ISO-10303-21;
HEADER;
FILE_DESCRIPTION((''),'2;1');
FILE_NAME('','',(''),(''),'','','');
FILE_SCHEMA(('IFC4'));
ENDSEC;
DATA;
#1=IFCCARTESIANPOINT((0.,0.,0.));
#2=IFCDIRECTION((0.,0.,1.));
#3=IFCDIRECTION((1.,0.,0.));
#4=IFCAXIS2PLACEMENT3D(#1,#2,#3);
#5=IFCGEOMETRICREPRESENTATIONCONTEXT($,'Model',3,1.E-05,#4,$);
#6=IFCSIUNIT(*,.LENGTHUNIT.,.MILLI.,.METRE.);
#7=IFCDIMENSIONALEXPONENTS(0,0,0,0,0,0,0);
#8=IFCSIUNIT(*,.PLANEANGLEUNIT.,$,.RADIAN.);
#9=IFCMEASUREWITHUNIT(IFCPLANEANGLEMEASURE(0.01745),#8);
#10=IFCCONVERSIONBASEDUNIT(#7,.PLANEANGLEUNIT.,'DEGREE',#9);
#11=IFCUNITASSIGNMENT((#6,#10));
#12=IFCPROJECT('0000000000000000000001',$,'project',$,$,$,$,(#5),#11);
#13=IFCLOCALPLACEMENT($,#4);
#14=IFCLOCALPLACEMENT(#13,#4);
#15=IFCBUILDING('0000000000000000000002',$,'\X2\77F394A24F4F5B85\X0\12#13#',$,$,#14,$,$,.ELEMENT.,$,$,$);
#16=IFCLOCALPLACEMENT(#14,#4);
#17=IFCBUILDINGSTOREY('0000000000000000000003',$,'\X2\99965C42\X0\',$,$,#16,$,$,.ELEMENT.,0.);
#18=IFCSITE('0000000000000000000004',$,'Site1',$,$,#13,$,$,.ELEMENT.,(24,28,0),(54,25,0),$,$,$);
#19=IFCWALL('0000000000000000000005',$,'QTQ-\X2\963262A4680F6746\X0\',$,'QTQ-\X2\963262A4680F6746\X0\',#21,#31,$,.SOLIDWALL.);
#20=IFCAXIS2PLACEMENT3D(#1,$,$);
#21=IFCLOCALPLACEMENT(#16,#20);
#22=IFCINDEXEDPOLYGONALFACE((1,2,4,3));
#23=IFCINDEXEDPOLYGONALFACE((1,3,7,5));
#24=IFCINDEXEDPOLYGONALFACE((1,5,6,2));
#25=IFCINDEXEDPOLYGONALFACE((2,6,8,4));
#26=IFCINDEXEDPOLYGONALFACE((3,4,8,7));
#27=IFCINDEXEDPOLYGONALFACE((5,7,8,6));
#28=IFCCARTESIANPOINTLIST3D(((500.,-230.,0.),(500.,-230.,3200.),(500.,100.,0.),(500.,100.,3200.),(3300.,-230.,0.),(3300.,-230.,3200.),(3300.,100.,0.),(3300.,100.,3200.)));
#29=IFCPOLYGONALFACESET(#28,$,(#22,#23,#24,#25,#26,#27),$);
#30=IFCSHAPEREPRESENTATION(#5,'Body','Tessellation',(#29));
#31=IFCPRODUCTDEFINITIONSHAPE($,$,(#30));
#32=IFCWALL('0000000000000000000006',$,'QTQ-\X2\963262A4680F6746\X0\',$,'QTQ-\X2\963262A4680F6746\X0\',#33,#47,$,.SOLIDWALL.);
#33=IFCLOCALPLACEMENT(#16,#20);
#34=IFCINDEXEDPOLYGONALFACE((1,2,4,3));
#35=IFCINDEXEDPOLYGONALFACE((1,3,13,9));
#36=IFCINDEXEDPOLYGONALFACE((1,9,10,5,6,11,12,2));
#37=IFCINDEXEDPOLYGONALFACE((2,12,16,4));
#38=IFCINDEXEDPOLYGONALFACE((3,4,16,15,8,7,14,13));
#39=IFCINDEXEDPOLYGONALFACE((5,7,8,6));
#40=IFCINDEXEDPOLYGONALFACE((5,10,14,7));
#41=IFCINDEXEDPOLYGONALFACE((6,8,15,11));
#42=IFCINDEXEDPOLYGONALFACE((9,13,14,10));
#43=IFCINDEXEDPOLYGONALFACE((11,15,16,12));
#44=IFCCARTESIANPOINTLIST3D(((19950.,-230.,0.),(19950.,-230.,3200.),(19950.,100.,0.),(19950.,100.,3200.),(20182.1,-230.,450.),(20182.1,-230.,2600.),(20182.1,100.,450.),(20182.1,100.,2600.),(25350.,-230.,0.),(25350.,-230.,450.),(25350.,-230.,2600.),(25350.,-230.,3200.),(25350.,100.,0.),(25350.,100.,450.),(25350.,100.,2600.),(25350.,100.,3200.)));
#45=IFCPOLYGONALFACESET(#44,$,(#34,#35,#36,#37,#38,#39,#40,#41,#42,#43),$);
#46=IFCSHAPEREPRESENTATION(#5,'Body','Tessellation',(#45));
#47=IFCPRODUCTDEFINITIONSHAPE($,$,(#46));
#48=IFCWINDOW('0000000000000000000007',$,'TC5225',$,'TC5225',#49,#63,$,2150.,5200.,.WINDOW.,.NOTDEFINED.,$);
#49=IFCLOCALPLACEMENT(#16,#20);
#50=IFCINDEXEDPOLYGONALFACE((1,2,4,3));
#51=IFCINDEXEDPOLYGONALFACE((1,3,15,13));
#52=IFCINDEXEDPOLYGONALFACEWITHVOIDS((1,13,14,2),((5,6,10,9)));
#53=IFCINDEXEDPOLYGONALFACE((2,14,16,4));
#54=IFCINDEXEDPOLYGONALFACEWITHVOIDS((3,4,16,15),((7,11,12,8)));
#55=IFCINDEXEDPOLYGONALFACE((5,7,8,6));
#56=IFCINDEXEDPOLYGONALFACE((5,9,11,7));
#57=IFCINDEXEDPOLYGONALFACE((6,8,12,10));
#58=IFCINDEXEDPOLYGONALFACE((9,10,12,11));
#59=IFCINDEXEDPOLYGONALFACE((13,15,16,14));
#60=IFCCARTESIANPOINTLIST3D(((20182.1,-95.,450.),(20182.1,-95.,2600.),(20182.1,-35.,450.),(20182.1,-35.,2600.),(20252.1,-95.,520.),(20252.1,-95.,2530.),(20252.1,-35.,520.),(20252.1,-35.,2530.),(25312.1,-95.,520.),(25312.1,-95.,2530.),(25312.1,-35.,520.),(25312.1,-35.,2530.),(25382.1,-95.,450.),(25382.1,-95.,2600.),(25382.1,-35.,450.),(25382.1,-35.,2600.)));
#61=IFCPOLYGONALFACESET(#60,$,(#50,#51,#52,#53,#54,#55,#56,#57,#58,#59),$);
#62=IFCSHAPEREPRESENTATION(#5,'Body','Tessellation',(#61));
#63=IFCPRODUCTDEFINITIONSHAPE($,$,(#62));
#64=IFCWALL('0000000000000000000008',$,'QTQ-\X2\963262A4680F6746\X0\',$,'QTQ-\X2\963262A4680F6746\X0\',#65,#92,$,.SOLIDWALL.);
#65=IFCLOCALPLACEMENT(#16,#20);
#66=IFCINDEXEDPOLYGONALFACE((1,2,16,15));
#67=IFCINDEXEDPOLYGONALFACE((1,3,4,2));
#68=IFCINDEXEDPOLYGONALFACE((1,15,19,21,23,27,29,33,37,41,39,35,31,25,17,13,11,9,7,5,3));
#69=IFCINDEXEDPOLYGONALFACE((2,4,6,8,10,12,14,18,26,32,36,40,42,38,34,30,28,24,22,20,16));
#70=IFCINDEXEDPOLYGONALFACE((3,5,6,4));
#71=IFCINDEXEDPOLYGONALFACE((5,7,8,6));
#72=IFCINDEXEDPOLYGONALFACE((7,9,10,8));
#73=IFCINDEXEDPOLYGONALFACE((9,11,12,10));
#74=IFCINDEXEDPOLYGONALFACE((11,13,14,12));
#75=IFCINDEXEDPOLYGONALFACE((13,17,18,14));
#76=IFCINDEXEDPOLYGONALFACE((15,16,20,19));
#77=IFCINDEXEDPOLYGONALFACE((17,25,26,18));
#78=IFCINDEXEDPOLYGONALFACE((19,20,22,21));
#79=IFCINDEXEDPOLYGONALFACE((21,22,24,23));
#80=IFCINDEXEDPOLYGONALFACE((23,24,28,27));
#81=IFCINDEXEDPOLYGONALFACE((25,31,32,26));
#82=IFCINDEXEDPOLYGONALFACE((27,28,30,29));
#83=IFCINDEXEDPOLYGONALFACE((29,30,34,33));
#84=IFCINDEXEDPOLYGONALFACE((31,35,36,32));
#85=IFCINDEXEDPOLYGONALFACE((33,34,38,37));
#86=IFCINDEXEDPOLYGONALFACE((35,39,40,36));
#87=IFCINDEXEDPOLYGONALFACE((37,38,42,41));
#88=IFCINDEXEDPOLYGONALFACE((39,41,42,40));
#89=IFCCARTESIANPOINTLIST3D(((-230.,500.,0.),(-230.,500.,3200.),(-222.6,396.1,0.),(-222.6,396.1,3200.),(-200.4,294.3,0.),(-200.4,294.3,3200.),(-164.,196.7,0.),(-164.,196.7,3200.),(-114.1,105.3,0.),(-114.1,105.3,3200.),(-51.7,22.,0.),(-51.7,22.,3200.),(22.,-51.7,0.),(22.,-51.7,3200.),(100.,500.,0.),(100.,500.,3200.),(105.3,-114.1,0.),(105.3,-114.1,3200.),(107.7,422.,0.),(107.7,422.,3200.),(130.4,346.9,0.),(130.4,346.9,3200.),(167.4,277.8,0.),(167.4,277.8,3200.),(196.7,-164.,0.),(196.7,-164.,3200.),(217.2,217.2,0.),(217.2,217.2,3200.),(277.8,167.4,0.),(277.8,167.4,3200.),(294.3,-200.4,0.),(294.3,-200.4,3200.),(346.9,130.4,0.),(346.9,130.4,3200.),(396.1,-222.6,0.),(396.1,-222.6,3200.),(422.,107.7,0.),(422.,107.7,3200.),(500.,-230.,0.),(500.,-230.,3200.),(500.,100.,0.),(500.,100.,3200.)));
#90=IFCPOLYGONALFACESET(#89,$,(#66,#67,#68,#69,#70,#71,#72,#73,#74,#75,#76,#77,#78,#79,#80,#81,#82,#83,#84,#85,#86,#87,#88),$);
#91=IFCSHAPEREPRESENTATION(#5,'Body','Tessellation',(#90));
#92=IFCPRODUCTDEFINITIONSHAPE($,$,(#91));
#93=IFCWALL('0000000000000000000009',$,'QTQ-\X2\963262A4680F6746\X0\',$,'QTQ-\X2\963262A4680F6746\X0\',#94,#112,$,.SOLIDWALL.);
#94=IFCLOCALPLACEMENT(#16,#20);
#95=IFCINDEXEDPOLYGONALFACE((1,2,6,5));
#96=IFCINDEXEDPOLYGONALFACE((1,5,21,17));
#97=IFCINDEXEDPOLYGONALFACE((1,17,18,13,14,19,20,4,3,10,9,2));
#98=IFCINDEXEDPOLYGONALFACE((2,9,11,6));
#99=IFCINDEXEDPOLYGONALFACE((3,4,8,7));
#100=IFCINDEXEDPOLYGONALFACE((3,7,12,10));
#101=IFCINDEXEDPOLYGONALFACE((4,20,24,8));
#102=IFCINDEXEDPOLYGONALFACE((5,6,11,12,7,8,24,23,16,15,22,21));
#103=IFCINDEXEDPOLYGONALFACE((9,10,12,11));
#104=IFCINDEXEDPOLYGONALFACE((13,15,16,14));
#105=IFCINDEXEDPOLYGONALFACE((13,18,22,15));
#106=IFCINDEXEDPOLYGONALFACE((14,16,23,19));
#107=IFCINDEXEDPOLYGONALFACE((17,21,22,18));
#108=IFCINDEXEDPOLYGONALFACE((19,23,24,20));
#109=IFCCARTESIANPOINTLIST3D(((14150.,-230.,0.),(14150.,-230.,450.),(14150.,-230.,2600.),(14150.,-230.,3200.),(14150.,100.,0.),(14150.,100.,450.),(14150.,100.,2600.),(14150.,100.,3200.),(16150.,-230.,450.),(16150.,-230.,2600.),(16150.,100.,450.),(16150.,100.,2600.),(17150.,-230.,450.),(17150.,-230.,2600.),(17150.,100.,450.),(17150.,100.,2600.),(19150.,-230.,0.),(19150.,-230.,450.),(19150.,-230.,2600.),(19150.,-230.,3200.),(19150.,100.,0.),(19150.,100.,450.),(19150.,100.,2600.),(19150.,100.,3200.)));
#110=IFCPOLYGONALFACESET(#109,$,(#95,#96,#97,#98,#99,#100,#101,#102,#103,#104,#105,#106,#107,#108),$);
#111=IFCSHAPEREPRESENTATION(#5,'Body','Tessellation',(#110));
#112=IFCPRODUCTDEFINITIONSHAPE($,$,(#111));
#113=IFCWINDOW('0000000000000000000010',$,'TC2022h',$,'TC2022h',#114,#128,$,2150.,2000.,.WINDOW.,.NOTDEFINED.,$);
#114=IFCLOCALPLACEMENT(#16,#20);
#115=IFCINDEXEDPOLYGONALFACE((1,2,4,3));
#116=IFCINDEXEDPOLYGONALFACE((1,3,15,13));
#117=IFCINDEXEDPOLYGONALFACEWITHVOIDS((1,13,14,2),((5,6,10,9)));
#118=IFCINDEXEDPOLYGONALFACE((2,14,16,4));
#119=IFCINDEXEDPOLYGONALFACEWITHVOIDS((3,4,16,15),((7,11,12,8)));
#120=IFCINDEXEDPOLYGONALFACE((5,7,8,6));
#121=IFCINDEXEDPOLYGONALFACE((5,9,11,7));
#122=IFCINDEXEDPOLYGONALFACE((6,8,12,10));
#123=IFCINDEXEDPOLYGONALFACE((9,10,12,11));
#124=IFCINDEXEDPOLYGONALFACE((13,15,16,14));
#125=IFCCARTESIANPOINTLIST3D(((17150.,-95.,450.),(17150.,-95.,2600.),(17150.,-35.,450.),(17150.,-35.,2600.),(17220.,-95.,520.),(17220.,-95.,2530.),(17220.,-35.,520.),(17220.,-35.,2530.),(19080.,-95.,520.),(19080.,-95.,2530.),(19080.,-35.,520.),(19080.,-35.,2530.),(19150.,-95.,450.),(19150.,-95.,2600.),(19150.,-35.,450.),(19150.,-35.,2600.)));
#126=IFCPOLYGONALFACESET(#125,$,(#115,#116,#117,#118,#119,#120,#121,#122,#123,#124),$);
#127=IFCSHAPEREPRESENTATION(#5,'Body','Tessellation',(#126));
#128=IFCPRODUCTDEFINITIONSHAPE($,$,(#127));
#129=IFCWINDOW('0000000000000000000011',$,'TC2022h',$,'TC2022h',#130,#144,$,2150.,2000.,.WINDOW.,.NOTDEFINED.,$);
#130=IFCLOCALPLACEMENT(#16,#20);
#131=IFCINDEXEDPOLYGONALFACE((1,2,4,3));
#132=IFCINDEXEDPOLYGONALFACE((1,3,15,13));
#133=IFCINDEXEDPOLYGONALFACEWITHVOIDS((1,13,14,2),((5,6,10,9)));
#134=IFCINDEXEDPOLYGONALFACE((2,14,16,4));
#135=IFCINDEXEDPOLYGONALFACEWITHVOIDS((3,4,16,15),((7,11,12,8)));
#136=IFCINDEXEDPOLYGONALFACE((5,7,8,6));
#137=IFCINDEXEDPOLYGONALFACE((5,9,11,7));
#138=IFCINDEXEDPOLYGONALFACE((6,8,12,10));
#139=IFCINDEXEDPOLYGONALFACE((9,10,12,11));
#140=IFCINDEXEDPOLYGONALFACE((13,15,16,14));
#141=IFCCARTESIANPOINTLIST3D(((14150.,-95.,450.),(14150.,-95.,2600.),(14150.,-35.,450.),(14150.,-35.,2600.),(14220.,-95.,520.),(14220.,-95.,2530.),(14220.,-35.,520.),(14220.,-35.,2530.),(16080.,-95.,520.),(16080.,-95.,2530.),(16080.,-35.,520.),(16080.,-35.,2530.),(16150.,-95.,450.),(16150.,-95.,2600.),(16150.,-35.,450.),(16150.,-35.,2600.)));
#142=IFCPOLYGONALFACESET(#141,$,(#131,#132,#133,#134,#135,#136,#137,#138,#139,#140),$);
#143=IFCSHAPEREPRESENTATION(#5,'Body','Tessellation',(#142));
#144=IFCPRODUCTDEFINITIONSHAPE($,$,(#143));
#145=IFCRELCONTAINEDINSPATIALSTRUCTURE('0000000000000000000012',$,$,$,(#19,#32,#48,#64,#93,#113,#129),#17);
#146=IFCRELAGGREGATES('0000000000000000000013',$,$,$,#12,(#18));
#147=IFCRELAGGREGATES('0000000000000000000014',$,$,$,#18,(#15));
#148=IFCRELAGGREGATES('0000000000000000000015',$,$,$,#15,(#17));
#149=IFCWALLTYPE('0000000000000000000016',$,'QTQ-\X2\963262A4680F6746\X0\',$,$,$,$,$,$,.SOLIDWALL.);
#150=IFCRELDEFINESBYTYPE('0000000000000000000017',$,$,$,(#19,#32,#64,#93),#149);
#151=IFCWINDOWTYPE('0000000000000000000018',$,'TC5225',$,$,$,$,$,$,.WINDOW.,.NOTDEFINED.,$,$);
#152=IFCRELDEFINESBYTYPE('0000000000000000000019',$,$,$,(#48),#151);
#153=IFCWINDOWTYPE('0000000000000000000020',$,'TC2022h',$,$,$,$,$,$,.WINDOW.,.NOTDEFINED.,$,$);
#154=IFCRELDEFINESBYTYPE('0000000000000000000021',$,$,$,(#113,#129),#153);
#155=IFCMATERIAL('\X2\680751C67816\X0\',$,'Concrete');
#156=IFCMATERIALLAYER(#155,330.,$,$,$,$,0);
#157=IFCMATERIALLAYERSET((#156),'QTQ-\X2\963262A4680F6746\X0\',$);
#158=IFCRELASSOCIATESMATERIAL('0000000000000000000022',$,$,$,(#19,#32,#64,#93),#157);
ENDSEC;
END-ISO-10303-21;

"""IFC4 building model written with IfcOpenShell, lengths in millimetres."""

from ifc_helpers import new_model, entity, si_unit, converted_unit, point, frame, frame_2d, origin_with_axes, place, context, project, spatial, polyline, circle_curve, trimmed, segment, composite_curve, outline, extrude, material, layer, layer_set, type_object, element, fill, save


model = new_model("IFC4")

# Units and contexts
model_context = context("Model", 3, precision=1e-05, world=origin_with_axes())
ifc_project = project(units=[si_unit("LENGTHUNIT", "METRE", prefix="MILLI"), converted_unit("PLANEANGLEUNIT", "DEGREE", entity("IfcPlaneAngleMeasure", 0.01745), si_unit("PLANEANGLEUNIT", "RADIAN"), dimensions=[0, 0, 0, 0, 0, 0, 0])], contexts=[model_context])

# Site, building, storey
site_placement = place(None, origin_with_axes())
site = spatial("IfcSite", under=ifc_project, at=site_placement, Name="Site1", CompositionType="ELEMENT", RefLatitude=(24, 28, 0), RefLongitude=(54, 25, 0))
building_placement = place(site_placement, origin_with_axes())
building = spatial("IfcBuilding", under=site, at=building_placement, Name="石钢住宅12#13#", CompositionType="ELEMENT")
storey_placement = place(building_placement, origin_with_axes())
storey = spatial("IfcBuildingStorey", under=building, at=storey_placement, Name="首层", CompositionType="ELEMENT", Elevation=0.0)

# Wall
ifc_material_1 = material(Name="标准砖", Category="Concrete")
ifc_layer_1 = layer(ifc_material_1, 330.0, Priority=0)
ifc_layer_set_1 = layer_set([ifc_layer_1], Name="QTQ-防护栏杆")
wall_type_1 = type_object("IfcWallType", Name="QTQ-防护栏杆", PredefinedType="SOLIDWALL")
wall_1_placement = place(storey_placement, origin_with_axes())
element("IfcWall", 1, at=wall_1_placement, inside=storey, type_object=wall_type_1, material=ifc_layer_set_1, Name="QTQ-防护栏杆", ObjectType="QTQ-防护栏杆", PredefinedType="SOLIDWALL", context=model_context, shape_type="SweptSolid", body=[
    extrude(outline(polyline([(0.0, 0.0), (3200.0, 0.0), (3200.0, 2800.0), (0.0, 2800.0), (0.0, 0.0)])), frame((500.0, 100.0, 3200.0), z_axis=(0.0, -1.0, 0.0), x_axis=(0.0, 0.0, -1.0)), (0.0, 0.0, 1.0), 330.0),
])

# Wall, opening, window
wall_2_placement = place(storey_placement, origin_with_axes())
wall_2 = element("IfcWall", 2, at=wall_2_placement, inside=storey, type_object=wall_type_1, material=ifc_layer_set_1, Name="QTQ-防护栏杆", ObjectType="QTQ-防护栏杆", PredefinedType="SOLIDWALL", context=model_context, shape_type="SweptSolid", body=[
    extrude(outline(polyline([(0.0, 0.0), (3200.0, 0.0), (3200.0, 5400.0), (0.0, 5400.0), (0.0, 0.0)])), frame((19950.0, 100.0, 3200.0), z_axis=(0.0, -1.0, 0.0), x_axis=(0.0, 0.0, -1.0)), (0.0, 0.0, 1.0), 330.0),
])
opening_1_placement = place(storey_placement, origin_with_axes())
opening_1 = element("IfcOpeningElement", 3, at=opening_1_placement, cuts=wall_2, PredefinedType="OPENING", context=model_context, shape_type="SweptSolid", body=[
    extrude(outline(polyline([(0.0, 0.0), (5200.0, 0.0), (5200.0, 2150.0), (0.0, 2150.0), (0.0, 0.0)])), frame((20182.1, 1100.0, 450.0), z_axis=(0.0, -1.0, 0.0), x_axis=(1.0, 0.0, 0.0)), (0.0, 0.0, 1.0), 2330.0),
])
window_type_1 = type_object("IfcWindowType", Name="TC5225", PartitioningType="NOTDEFINED", PredefinedType="WINDOW")
window_1_placement = place(storey_placement, origin_with_axes())
window_1 = element("IfcWindow", 4, at=window_1_placement, inside=storey, type_object=window_type_1, Name="TC5225", ObjectType="TC5225", OverallHeight=2150.0, OverallWidth=5200.0, PartitioningType="NOTDEFINED", PredefinedType="WINDOW", context=model_context, shape_type="SweptSolid", body=[
    extrude(outline(polyline([(-2600.0, -1075.0), (2600.0, -1075.0), (2600.0, 1075.0), (-2600.0, 1075.0), (-2600.0, -1075.0)]), holes=[polyline([(-2530.0, -1005.0), (-2530.0, 1005.0), (2530.0, 1005.0), (2530.0, -1005.0), (-2530.0, -1005.0)])]), frame((22782.1, -35.0, 1525.0), z_axis=(0.0, -1.0, 0.0), x_axis=(1.0, 0.0, 0.0)), (0.0, 0.0, 1.0), 60.0),
])
fill(opening_1, window_1)

# Wall
wall_3_placement = place(storey_placement, origin_with_axes())
element("IfcWall", 5, at=wall_3_placement, inside=storey, type_object=wall_type_1, material=ifc_layer_set_1, Name="QTQ-防护栏杆", ObjectType="QTQ-防护栏杆", PredefinedType="SOLIDWALL", context=model_context, shape_type="SweptSolid", body=[
    extrude(outline(composite_curve([segment(polyline([(100.0, 500.0), (-230.0, 500.0)]), True, "CONTINUOUS"), segment(trimmed(circle_curve(frame_2d((500.0, 500.0), x_axis=(1.0, 0.0)), 730.0), [point((-230.0, 500.0))], [point((500.0, -230.0))], True, "CARTESIAN"), True, "CONTINUOUS"), segment(polyline([(500.0, -230.0), (500.0, 100.0)]), True, "CONTINUOUS"), segment(trimmed(circle_curve(frame_2d((500.0, 500.0), x_axis=(1.0, 0.0)), 400.0), [point((500.0, 100.0))], [point((100.0, 500.0))], False, "CARTESIAN"), True, "CONTINUOUS")], self_intersect=False)), origin_with_axes(), (0.0, 0.0, 1.0), 3200.0),
])

# Wall, openings, windows
wall_4_placement = place(storey_placement, origin_with_axes())
wall_4 = element("IfcWall", 6, at=wall_4_placement, inside=storey, type_object=wall_type_1, material=ifc_layer_set_1, Name="QTQ-防护栏杆", ObjectType="QTQ-防护栏杆", PredefinedType="SOLIDWALL", context=model_context, shape_type="SweptSolid", body=[
    extrude(outline(polyline([(0.0, 0.0), (3200.0, 0.0), (3200.0, 5000.0), (0.0, 5000.0), (0.0, 0.0)])), frame((14150.0, 100.0, 3200.0), z_axis=(0.0, -1.0, 0.0), x_axis=(0.0, 0.0, -1.0)), (0.0, 0.0, 1.0), 330.0),
])
opening_2_placement = place(storey_placement, origin_with_axes())
opening_2 = element("IfcOpeningElement", 7, at=opening_2_placement, cuts=wall_4, PredefinedType="OPENING", context=model_context, shape_type="SweptSolid", body=[
    extrude(outline(polyline([(0.0, 0.0), (2000.0, 0.0), (2000.0, 2150.0), (0.0, 2150.0), (0.0, 0.0)])), frame((17150.0, 1100.0, 450.0), z_axis=(0.0, -1.0, 0.0), x_axis=(1.0, 0.0, 0.0)), (0.0, 0.0, 1.0), 2330.0),
])
opening_3_placement = place(storey_placement, origin_with_axes())
opening_3 = element("IfcOpeningElement", 8, at=opening_3_placement, cuts=wall_4, PredefinedType="OPENING", context=model_context, shape_type="SweptSolid", body=[
    extrude(outline(polyline([(0.0, 0.0), (2000.0, 0.0), (2000.0, 2150.0), (0.0, 2150.0), (0.0, 0.0)])), frame((14150.0, 1100.0, 450.0), z_axis=(0.0, -1.0, 0.0), x_axis=(1.0, 0.0, 0.0)), (0.0, 0.0, 1.0), 2330.0),
])
window_type_2 = type_object("IfcWindowType", Name="TC2022h", PartitioningType="NOTDEFINED", PredefinedType="WINDOW")
window_2_placement = place(storey_placement, origin_with_axes())
window_2 = element("IfcWindow", 9, at=window_2_placement, inside=storey, type_object=window_type_2, Name="TC2022h", ObjectType="TC2022h", OverallHeight=2150.0, OverallWidth=2000.0, PartitioningType="NOTDEFINED", PredefinedType="WINDOW", context=model_context, shape_type="SweptSolid", body=[
    extrude(outline(polyline([(-1000.0, -1075.0), (1000.0, -1075.0), (1000.0, 1075.0), (-1000.0, 1075.0), (-1000.0, -1075.0)]), holes=[polyline([(-930.0, -1005.0), (-930.0, 1005.0), (930.0, 1005.0), (930.0, -1005.0), (-930.0, -1005.0)])]), frame((18150.0, -35.0, 1525.0), z_axis=(0.0, -1.0, 0.0), x_axis=(1.0, 0.0, 0.0)), (0.0, 0.0, 1.0), 60.0),
])
fill(opening_2, window_2)
window_3_placement = place(storey_placement, origin_with_axes())
window_3 = element("IfcWindow", 10, at=window_3_placement, inside=storey, type_object=window_type_2, Name="TC2022h", ObjectType="TC2022h", OverallHeight=2150.0, OverallWidth=2000.0, PartitioningType="NOTDEFINED", PredefinedType="WINDOW", context=model_context, shape_type="SweptSolid", body=[
    extrude(outline(polyline([(-1000.0, -1075.0), (1000.0, -1075.0), (1000.0, 1075.0), (-1000.0, 1075.0), (-1000.0, -1075.0)]), holes=[polyline([(-930.0, -1005.0), (-930.0, 1005.0), (930.0, 1005.0), (930.0, -1005.0), (-930.0, -1005.0)])]), frame((15150.0, -35.0, 1525.0), z_axis=(0.0, -1.0, 0.0), x_axis=(1.0, 0.0, 0.0)), (0.0, 0.0, 1.0), 60.0),
])
fill(opening_3, window_3)

save(model, "model.ifc")
